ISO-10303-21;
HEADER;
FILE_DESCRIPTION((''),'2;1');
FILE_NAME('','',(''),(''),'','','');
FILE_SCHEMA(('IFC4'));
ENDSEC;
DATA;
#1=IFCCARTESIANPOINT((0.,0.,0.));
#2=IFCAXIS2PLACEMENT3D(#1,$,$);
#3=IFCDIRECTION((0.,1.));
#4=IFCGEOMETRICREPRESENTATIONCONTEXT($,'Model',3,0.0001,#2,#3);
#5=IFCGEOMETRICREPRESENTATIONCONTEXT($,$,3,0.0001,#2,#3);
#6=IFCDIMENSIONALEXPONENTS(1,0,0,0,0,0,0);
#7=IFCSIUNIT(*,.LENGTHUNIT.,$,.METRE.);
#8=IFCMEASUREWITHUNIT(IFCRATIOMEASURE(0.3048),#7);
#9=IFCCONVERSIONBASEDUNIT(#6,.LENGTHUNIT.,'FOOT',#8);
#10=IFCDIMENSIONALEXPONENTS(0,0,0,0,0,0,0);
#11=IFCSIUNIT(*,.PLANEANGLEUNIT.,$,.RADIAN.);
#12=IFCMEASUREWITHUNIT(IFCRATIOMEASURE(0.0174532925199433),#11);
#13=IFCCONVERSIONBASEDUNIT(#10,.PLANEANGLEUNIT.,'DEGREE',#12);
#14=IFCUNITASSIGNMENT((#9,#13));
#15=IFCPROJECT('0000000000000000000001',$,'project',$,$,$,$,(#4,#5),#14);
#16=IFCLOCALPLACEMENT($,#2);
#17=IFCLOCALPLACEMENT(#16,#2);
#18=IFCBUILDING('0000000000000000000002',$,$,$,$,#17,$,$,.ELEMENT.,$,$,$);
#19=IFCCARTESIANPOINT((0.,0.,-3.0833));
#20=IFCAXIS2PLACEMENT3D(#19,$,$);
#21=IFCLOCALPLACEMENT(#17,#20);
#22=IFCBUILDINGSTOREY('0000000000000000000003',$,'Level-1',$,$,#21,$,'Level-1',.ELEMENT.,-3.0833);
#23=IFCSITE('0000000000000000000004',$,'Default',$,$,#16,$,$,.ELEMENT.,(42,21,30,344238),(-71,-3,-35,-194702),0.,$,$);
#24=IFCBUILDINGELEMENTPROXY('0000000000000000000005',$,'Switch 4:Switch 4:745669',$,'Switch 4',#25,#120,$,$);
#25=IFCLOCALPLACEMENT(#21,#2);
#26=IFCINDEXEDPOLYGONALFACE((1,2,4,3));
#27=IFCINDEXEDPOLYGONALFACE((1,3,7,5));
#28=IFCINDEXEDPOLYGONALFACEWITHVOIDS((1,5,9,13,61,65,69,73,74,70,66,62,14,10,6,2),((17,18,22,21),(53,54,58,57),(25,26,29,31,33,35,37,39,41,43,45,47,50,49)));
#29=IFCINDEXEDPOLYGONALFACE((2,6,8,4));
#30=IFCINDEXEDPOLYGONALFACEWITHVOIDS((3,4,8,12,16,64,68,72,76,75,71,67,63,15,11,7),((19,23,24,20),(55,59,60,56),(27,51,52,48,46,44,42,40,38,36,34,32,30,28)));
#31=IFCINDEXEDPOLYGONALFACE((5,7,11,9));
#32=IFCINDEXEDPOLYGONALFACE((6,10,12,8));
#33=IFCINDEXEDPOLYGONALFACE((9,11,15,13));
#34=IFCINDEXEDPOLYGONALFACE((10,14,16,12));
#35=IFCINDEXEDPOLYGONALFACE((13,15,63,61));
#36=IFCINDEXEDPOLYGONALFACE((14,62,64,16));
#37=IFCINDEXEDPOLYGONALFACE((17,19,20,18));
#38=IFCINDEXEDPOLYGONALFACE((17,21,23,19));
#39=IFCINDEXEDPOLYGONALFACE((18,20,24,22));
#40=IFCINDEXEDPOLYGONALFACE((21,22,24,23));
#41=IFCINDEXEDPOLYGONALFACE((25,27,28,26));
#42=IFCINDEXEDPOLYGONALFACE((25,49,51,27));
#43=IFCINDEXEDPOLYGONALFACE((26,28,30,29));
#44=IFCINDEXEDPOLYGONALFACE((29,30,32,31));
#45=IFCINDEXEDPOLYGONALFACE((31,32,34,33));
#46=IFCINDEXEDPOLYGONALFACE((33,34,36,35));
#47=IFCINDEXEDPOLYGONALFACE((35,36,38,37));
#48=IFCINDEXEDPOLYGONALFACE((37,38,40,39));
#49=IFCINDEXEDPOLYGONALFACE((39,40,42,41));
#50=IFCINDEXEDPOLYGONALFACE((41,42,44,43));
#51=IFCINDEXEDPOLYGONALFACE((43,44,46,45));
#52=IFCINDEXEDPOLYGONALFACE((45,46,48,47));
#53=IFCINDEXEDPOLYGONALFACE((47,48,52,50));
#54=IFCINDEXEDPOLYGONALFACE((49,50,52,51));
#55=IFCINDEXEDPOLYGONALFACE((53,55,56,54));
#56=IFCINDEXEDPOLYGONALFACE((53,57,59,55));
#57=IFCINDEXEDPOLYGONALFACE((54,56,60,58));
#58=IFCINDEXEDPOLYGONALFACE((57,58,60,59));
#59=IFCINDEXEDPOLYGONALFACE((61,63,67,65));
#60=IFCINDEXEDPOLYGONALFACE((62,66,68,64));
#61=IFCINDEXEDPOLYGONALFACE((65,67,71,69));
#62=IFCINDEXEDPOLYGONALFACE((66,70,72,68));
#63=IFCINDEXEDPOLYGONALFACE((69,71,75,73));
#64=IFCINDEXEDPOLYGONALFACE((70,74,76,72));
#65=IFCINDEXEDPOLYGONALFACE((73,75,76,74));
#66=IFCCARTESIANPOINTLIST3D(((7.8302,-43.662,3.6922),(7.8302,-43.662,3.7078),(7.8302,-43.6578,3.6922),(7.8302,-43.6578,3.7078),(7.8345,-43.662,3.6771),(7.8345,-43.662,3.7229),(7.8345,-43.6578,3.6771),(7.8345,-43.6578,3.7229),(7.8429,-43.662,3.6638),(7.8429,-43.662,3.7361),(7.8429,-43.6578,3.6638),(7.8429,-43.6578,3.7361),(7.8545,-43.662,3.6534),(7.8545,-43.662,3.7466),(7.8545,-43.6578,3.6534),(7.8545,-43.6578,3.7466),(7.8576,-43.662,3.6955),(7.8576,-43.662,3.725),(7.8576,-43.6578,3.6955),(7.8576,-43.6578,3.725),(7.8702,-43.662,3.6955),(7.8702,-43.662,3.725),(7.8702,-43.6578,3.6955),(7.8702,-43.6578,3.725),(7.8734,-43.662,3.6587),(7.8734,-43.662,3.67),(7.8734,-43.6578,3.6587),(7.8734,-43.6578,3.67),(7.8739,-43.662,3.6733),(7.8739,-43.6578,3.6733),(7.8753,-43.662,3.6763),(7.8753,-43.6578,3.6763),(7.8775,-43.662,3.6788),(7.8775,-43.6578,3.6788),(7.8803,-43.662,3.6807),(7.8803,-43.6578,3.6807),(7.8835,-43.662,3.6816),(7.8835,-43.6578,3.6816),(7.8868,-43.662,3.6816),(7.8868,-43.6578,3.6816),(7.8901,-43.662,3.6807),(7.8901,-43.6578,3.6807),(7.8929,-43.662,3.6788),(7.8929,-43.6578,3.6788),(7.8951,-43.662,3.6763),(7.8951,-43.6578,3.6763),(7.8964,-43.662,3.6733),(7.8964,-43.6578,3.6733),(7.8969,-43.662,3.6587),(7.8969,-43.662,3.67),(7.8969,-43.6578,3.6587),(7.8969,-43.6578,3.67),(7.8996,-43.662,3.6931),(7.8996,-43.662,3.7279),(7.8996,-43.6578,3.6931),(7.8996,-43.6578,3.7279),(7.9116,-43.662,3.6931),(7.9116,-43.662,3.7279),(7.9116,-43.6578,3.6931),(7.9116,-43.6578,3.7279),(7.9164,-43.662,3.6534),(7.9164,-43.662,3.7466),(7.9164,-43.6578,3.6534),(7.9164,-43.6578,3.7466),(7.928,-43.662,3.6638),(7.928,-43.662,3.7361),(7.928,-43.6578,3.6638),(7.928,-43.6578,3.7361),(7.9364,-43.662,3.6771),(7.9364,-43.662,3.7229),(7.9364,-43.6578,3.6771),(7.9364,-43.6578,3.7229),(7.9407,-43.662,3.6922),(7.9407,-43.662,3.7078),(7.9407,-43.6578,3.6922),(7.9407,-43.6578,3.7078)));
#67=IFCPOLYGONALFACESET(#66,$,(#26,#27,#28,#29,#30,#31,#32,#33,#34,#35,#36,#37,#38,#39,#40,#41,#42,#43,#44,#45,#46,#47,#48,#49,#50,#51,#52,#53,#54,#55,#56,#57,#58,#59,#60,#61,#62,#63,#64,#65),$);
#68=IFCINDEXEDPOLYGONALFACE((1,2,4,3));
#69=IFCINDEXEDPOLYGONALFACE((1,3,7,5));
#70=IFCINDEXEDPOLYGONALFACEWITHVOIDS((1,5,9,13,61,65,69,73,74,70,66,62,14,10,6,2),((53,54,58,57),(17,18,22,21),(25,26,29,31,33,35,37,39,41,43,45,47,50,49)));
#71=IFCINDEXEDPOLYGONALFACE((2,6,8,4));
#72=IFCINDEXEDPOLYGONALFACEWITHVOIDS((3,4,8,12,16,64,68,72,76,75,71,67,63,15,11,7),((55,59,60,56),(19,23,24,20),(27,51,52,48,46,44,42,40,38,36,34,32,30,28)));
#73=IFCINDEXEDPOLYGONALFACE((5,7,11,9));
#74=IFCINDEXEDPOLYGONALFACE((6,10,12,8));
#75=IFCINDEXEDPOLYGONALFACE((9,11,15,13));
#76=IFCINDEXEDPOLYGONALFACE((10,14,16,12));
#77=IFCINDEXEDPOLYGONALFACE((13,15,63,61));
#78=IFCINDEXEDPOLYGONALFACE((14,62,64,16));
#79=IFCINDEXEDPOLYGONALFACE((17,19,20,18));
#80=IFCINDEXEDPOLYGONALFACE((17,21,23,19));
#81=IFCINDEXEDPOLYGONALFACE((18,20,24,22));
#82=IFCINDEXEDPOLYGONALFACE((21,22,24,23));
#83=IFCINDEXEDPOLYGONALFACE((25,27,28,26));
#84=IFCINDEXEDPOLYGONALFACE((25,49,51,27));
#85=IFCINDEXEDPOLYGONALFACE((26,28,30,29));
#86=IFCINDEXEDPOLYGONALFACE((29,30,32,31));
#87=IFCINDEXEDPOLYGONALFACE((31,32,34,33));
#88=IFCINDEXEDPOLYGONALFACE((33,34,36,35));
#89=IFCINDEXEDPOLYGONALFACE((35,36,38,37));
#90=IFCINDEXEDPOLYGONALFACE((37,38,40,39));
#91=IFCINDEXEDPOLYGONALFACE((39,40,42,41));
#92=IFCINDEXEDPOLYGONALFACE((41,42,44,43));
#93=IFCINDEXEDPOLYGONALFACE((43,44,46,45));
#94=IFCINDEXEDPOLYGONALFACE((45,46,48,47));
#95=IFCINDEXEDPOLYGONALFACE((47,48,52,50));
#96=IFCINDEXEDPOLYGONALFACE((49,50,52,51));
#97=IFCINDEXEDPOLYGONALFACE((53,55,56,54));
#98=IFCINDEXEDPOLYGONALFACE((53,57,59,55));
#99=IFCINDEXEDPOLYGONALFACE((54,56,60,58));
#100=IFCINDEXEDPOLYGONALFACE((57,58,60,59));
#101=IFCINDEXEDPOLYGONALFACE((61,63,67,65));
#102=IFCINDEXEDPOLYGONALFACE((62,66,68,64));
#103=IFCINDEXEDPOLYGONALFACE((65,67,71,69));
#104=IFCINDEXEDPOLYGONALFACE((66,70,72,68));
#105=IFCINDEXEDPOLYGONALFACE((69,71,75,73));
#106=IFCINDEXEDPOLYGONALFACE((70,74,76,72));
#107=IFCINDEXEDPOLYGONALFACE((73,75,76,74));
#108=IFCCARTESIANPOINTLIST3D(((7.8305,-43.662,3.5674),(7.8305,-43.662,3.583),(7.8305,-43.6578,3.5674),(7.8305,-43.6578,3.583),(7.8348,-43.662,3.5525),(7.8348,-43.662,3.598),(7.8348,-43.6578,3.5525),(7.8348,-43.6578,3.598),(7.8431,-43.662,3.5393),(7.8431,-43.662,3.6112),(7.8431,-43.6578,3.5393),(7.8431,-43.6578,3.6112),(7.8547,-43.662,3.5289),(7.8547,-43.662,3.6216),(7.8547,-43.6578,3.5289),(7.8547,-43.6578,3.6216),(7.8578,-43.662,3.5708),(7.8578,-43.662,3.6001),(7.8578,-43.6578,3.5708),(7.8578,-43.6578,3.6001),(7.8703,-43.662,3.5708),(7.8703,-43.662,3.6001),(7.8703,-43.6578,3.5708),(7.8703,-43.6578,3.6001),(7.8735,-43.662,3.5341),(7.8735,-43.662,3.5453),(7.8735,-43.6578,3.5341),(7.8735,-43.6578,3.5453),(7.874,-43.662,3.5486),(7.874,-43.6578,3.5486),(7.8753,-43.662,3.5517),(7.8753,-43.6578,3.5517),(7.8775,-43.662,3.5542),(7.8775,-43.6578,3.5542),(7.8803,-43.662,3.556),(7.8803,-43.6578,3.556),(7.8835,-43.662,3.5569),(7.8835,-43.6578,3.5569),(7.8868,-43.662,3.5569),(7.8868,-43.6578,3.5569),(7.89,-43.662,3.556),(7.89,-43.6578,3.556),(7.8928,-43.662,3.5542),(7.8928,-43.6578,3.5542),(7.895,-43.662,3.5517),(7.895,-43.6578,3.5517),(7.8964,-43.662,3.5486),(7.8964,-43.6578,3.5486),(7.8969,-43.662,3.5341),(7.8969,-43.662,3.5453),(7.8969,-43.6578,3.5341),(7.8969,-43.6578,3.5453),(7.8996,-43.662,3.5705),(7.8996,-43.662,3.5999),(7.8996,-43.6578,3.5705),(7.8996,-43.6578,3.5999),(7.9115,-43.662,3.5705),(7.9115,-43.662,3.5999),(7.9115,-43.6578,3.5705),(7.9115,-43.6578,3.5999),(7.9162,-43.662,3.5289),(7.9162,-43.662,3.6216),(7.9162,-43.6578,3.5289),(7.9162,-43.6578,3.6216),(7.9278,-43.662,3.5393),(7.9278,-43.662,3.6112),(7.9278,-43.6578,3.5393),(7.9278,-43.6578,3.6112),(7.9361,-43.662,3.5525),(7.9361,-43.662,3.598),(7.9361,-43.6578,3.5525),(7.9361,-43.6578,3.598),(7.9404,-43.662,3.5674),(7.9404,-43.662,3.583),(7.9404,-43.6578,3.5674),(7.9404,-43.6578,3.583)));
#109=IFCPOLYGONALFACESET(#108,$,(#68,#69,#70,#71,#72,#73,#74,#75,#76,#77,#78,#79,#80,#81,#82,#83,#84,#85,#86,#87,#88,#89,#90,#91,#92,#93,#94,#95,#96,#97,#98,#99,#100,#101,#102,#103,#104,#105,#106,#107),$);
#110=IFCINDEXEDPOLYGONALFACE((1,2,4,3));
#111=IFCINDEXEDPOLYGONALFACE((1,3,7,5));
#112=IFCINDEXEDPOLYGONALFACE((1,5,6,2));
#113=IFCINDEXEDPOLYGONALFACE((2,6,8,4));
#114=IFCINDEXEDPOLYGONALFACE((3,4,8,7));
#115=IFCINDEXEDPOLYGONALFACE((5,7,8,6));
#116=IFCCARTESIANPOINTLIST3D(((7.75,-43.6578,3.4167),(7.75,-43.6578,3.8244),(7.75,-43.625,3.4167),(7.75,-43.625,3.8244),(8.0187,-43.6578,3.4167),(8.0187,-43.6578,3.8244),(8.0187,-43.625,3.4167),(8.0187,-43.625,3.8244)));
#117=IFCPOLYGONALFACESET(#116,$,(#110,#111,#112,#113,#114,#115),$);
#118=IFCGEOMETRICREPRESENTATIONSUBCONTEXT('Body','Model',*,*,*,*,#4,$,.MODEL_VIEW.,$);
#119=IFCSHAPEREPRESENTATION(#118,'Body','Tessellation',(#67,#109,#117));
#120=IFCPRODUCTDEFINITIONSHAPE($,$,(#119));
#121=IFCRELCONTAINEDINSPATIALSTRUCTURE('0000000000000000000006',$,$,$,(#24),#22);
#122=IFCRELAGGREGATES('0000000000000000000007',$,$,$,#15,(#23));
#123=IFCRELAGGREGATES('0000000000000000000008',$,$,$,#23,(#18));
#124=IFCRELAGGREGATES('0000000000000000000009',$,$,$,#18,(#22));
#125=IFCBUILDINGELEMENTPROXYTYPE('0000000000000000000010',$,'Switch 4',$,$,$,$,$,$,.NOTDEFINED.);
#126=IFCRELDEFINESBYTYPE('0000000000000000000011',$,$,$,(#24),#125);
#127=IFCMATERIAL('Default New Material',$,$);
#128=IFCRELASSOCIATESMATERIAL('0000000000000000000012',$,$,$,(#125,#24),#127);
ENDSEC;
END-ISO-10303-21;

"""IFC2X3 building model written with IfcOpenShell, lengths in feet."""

from ifc_helpers import new_model, entity, si_unit, converted_unit, direction, frame, frame_2d, origin, origin_2d_with_axis, place, context, subcontext, project, spatial, polyline, circle_curve, parameter, trimmed, segment, composite_curve, rectangle, outline, extrude, source, transform, mapped, material, type_object, type_shapes, element, save


model = new_model("IFC2X3")

# Units and contexts
model_context = context("Model", 3, precision=0.0001, world=origin(), true_north=direction((0.0, 1.0)))
context_of_model = context(None, 3, precision=0.0001, world=origin(), true_north=direction((0.0, 1.0)))
body_context = subcontext(model_context, "Body", "Model", "MODEL_VIEW")
ifc_project = project(units=[converted_unit("LENGTHUNIT", "FOOT", entity("IfcRatioMeasure", 0.3048), si_unit("LENGTHUNIT", "METRE"), dimensions=[1, 0, 0, 0, 0, 0, 0]), converted_unit("PLANEANGLEUNIT", "DEGREE", entity("IfcRatioMeasure", 0.0174532925199433), si_unit("PLANEANGLEUNIT", "RADIAN"), dimensions=[0, 0, 0, 0, 0, 0, 0])], contexts=[model_context, context_of_model])

# Site, building, storey
site_placement = place(None, origin())
site = spatial("IfcSite", under=ifc_project, at=site_placement, Name="Default", CompositionType="ELEMENT", RefLatitude=(42, 21, 30, 344238), RefLongitude=(-71, -3, -35, -194702), RefElevation=0.0)
building_placement = place(site_placement, origin())
building = spatial("IfcBuilding", under=site, at=building_placement, CompositionType="ELEMENT")
storey_placement = place(building_placement, frame((0.0, 0.0, -3.0833)))
storey = spatial("IfcBuildingStorey", under=building, at=storey_placement, Name="Level-1", LongName="Level-1", CompositionType="ELEMENT", Elevation=-3.0833)

# Shared definitions
ifc_material = material(Name="Default New Material")

# Building element proxy
building_element_proxy_type_1 = type_object("IfcBuildingElementProxyType", Name="Switch 4", PredefinedType="NOTDEFINED", material=ifc_material)
shared_shape_1 = source(origin(), body_context, "Body", "SweptSolid", [
    extrude(outline(composite_curve([segment(polyline([(-0.0309, -0.0466), (0.0309, -0.0466)]), True, "CONTINUOUS"), segment(trimmed(circle_curve(frame_2d((-0.0003, 0.0), x_axis=(-1.0, 0.0)), 0.0561), [parameter(123.794741)], [parameter(236.205259)], True, "PARAMETER"), True, "CONTINUOUS"), segment(polyline([(0.0309, 0.0466), (-0.0309, 0.0466)]), True, "CONTINUOUS"), segment(trimmed(circle_curve(frame_2d((0.0003, 0.0), x_axis=(1.0, 0.0)), 0.0561), [parameter(123.794741)], [parameter(236.205259)], True, "PARAMETER"), True, "CONTINUOUS")], self_intersect=False), holes=[polyline([(0.0142, 0.0279), (0.0262, 0.0279), (0.0262, -0.0069), (0.0142, -0.0069), (0.0142, 0.0279)]), polyline([(-0.0153, 0.025), (-0.0153, -0.0045), (-0.0278, -0.0045), (-0.0278, 0.025), (-0.0153, 0.025)]), composite_curve([segment(polyline([(-0.012, -0.0413), (-0.012, -0.03)]), True, "CONTINUOUS"), segment(trimmed(circle_curve(frame_2d((-0.0003, -0.03), x_axis=(-1.0, 0.0)), 0.0117), [parameter(180.0)], [parameter(0.0)], True, "PARAMETER"), False, "CONTINUOUS"), segment(polyline([(0.0115, -0.03), (0.0115, -0.0413)]), True, "CONTINUOUS"), segment(polyline([(0.0115, -0.0413), (-0.012, -0.0413)]), True, "CONTINUOUS")], self_intersect=False)]), frame((-0.0011, 0.0328, 0.2833), z_axis=(0.0, 1.0, 0.0), x_axis=(-1.0, 0.0, 0.0)), (0.0, 0.0, 1.0), 0.0042),
    extrude(outline(composite_curve([segment(polyline([(-0.0308, -0.0464), (0.0308, -0.0464)]), True, "CONTINUOUS"), segment(trimmed(circle_curve(frame_2d((-0.0003, 0.0), x_axis=(-1.0, 0.0)), 0.0558), [parameter(123.794741)], [parameter(236.205259)], True, "PARAMETER"), True, "CONTINUOUS"), segment(polyline([(0.0308, 0.0464), (-0.0308, 0.0464)]), True, "CONTINUOUS"), segment(trimmed(circle_curve(frame_2d((0.0003, 0.0), x_axis=(1.0, 0.0)), 0.0558), [parameter(123.794741)], [parameter(236.205259)], True, "PARAMETER"), True, "CONTINUOUS")], self_intersect=False), holes=[polyline([(0.0141, 0.0247), (0.026, 0.0247), (0.026, -0.0047), (0.0141, -0.0047), (0.0141, 0.0247)]), polyline([(-0.0152, 0.0249), (-0.0152, -0.0045), (-0.0277, -0.0045), (-0.0277, 0.0249), (-0.0152, 0.0249)]), composite_curve([segment(polyline([(-0.012, -0.0411), (-0.012, -0.0299)]), True, "CONTINUOUS"), segment(trimmed(circle_curve(frame_2d((-0.0003, -0.0299), x_axis=(-1.0, 0.0)), 0.0117), [parameter(180.0)], [parameter(0.0)], True, "PARAMETER"), False, "CONTINUOUS"), segment(polyline([(0.0114, -0.0299), (0.0114, -0.0411)]), True, "CONTINUOUS"), segment(polyline([(0.0114, -0.0411), (-0.012, -0.0411)]), True, "CONTINUOUS")], self_intersect=False)]), frame((-0.0011, 0.0328, 0.1586), z_axis=(0.0, 1.0, 0.0), x_axis=(-1.0, 0.0, 0.0)), (0.0, 0.0, 1.0), 0.0042),
    extrude(rectangle(XDim=0.0328, YDim=0.2687, at=origin_2d_with_axis()), frame((0.0, 0.0164, 0.0), z_axis=(0.0, 0.0, 1.0), x_axis=(0.0, -1.0, 0.0)), (0.0, 0.0, 1.0), 0.4078),
])
type_shapes(building_element_proxy_type_1, [shared_shape_1])
for number, where, z_axis, x_axis, name in (
    (1, (7.8843, -43.625, 3.4167), (0.0, 0.0, 1.0), (-1.0, 0.0, 0.0), "Switch 4:Switch 4:745669"),
):
    element("IfcBuildingElementProxy", number, at=place(storey_placement, frame(where, z_axis=z_axis, x_axis=x_axis)), inside=storey, type_object=building_element_proxy_type_1, material=ifc_material, Name=name, ObjectType="Switch 4", context=body_context, shape_type="MappedRepresentation", body=[
        mapped(shared_shape_1, transform((0.0, 0.0, 0.0), scale=1.0)),
    ])

save(model, "model.ifc")
